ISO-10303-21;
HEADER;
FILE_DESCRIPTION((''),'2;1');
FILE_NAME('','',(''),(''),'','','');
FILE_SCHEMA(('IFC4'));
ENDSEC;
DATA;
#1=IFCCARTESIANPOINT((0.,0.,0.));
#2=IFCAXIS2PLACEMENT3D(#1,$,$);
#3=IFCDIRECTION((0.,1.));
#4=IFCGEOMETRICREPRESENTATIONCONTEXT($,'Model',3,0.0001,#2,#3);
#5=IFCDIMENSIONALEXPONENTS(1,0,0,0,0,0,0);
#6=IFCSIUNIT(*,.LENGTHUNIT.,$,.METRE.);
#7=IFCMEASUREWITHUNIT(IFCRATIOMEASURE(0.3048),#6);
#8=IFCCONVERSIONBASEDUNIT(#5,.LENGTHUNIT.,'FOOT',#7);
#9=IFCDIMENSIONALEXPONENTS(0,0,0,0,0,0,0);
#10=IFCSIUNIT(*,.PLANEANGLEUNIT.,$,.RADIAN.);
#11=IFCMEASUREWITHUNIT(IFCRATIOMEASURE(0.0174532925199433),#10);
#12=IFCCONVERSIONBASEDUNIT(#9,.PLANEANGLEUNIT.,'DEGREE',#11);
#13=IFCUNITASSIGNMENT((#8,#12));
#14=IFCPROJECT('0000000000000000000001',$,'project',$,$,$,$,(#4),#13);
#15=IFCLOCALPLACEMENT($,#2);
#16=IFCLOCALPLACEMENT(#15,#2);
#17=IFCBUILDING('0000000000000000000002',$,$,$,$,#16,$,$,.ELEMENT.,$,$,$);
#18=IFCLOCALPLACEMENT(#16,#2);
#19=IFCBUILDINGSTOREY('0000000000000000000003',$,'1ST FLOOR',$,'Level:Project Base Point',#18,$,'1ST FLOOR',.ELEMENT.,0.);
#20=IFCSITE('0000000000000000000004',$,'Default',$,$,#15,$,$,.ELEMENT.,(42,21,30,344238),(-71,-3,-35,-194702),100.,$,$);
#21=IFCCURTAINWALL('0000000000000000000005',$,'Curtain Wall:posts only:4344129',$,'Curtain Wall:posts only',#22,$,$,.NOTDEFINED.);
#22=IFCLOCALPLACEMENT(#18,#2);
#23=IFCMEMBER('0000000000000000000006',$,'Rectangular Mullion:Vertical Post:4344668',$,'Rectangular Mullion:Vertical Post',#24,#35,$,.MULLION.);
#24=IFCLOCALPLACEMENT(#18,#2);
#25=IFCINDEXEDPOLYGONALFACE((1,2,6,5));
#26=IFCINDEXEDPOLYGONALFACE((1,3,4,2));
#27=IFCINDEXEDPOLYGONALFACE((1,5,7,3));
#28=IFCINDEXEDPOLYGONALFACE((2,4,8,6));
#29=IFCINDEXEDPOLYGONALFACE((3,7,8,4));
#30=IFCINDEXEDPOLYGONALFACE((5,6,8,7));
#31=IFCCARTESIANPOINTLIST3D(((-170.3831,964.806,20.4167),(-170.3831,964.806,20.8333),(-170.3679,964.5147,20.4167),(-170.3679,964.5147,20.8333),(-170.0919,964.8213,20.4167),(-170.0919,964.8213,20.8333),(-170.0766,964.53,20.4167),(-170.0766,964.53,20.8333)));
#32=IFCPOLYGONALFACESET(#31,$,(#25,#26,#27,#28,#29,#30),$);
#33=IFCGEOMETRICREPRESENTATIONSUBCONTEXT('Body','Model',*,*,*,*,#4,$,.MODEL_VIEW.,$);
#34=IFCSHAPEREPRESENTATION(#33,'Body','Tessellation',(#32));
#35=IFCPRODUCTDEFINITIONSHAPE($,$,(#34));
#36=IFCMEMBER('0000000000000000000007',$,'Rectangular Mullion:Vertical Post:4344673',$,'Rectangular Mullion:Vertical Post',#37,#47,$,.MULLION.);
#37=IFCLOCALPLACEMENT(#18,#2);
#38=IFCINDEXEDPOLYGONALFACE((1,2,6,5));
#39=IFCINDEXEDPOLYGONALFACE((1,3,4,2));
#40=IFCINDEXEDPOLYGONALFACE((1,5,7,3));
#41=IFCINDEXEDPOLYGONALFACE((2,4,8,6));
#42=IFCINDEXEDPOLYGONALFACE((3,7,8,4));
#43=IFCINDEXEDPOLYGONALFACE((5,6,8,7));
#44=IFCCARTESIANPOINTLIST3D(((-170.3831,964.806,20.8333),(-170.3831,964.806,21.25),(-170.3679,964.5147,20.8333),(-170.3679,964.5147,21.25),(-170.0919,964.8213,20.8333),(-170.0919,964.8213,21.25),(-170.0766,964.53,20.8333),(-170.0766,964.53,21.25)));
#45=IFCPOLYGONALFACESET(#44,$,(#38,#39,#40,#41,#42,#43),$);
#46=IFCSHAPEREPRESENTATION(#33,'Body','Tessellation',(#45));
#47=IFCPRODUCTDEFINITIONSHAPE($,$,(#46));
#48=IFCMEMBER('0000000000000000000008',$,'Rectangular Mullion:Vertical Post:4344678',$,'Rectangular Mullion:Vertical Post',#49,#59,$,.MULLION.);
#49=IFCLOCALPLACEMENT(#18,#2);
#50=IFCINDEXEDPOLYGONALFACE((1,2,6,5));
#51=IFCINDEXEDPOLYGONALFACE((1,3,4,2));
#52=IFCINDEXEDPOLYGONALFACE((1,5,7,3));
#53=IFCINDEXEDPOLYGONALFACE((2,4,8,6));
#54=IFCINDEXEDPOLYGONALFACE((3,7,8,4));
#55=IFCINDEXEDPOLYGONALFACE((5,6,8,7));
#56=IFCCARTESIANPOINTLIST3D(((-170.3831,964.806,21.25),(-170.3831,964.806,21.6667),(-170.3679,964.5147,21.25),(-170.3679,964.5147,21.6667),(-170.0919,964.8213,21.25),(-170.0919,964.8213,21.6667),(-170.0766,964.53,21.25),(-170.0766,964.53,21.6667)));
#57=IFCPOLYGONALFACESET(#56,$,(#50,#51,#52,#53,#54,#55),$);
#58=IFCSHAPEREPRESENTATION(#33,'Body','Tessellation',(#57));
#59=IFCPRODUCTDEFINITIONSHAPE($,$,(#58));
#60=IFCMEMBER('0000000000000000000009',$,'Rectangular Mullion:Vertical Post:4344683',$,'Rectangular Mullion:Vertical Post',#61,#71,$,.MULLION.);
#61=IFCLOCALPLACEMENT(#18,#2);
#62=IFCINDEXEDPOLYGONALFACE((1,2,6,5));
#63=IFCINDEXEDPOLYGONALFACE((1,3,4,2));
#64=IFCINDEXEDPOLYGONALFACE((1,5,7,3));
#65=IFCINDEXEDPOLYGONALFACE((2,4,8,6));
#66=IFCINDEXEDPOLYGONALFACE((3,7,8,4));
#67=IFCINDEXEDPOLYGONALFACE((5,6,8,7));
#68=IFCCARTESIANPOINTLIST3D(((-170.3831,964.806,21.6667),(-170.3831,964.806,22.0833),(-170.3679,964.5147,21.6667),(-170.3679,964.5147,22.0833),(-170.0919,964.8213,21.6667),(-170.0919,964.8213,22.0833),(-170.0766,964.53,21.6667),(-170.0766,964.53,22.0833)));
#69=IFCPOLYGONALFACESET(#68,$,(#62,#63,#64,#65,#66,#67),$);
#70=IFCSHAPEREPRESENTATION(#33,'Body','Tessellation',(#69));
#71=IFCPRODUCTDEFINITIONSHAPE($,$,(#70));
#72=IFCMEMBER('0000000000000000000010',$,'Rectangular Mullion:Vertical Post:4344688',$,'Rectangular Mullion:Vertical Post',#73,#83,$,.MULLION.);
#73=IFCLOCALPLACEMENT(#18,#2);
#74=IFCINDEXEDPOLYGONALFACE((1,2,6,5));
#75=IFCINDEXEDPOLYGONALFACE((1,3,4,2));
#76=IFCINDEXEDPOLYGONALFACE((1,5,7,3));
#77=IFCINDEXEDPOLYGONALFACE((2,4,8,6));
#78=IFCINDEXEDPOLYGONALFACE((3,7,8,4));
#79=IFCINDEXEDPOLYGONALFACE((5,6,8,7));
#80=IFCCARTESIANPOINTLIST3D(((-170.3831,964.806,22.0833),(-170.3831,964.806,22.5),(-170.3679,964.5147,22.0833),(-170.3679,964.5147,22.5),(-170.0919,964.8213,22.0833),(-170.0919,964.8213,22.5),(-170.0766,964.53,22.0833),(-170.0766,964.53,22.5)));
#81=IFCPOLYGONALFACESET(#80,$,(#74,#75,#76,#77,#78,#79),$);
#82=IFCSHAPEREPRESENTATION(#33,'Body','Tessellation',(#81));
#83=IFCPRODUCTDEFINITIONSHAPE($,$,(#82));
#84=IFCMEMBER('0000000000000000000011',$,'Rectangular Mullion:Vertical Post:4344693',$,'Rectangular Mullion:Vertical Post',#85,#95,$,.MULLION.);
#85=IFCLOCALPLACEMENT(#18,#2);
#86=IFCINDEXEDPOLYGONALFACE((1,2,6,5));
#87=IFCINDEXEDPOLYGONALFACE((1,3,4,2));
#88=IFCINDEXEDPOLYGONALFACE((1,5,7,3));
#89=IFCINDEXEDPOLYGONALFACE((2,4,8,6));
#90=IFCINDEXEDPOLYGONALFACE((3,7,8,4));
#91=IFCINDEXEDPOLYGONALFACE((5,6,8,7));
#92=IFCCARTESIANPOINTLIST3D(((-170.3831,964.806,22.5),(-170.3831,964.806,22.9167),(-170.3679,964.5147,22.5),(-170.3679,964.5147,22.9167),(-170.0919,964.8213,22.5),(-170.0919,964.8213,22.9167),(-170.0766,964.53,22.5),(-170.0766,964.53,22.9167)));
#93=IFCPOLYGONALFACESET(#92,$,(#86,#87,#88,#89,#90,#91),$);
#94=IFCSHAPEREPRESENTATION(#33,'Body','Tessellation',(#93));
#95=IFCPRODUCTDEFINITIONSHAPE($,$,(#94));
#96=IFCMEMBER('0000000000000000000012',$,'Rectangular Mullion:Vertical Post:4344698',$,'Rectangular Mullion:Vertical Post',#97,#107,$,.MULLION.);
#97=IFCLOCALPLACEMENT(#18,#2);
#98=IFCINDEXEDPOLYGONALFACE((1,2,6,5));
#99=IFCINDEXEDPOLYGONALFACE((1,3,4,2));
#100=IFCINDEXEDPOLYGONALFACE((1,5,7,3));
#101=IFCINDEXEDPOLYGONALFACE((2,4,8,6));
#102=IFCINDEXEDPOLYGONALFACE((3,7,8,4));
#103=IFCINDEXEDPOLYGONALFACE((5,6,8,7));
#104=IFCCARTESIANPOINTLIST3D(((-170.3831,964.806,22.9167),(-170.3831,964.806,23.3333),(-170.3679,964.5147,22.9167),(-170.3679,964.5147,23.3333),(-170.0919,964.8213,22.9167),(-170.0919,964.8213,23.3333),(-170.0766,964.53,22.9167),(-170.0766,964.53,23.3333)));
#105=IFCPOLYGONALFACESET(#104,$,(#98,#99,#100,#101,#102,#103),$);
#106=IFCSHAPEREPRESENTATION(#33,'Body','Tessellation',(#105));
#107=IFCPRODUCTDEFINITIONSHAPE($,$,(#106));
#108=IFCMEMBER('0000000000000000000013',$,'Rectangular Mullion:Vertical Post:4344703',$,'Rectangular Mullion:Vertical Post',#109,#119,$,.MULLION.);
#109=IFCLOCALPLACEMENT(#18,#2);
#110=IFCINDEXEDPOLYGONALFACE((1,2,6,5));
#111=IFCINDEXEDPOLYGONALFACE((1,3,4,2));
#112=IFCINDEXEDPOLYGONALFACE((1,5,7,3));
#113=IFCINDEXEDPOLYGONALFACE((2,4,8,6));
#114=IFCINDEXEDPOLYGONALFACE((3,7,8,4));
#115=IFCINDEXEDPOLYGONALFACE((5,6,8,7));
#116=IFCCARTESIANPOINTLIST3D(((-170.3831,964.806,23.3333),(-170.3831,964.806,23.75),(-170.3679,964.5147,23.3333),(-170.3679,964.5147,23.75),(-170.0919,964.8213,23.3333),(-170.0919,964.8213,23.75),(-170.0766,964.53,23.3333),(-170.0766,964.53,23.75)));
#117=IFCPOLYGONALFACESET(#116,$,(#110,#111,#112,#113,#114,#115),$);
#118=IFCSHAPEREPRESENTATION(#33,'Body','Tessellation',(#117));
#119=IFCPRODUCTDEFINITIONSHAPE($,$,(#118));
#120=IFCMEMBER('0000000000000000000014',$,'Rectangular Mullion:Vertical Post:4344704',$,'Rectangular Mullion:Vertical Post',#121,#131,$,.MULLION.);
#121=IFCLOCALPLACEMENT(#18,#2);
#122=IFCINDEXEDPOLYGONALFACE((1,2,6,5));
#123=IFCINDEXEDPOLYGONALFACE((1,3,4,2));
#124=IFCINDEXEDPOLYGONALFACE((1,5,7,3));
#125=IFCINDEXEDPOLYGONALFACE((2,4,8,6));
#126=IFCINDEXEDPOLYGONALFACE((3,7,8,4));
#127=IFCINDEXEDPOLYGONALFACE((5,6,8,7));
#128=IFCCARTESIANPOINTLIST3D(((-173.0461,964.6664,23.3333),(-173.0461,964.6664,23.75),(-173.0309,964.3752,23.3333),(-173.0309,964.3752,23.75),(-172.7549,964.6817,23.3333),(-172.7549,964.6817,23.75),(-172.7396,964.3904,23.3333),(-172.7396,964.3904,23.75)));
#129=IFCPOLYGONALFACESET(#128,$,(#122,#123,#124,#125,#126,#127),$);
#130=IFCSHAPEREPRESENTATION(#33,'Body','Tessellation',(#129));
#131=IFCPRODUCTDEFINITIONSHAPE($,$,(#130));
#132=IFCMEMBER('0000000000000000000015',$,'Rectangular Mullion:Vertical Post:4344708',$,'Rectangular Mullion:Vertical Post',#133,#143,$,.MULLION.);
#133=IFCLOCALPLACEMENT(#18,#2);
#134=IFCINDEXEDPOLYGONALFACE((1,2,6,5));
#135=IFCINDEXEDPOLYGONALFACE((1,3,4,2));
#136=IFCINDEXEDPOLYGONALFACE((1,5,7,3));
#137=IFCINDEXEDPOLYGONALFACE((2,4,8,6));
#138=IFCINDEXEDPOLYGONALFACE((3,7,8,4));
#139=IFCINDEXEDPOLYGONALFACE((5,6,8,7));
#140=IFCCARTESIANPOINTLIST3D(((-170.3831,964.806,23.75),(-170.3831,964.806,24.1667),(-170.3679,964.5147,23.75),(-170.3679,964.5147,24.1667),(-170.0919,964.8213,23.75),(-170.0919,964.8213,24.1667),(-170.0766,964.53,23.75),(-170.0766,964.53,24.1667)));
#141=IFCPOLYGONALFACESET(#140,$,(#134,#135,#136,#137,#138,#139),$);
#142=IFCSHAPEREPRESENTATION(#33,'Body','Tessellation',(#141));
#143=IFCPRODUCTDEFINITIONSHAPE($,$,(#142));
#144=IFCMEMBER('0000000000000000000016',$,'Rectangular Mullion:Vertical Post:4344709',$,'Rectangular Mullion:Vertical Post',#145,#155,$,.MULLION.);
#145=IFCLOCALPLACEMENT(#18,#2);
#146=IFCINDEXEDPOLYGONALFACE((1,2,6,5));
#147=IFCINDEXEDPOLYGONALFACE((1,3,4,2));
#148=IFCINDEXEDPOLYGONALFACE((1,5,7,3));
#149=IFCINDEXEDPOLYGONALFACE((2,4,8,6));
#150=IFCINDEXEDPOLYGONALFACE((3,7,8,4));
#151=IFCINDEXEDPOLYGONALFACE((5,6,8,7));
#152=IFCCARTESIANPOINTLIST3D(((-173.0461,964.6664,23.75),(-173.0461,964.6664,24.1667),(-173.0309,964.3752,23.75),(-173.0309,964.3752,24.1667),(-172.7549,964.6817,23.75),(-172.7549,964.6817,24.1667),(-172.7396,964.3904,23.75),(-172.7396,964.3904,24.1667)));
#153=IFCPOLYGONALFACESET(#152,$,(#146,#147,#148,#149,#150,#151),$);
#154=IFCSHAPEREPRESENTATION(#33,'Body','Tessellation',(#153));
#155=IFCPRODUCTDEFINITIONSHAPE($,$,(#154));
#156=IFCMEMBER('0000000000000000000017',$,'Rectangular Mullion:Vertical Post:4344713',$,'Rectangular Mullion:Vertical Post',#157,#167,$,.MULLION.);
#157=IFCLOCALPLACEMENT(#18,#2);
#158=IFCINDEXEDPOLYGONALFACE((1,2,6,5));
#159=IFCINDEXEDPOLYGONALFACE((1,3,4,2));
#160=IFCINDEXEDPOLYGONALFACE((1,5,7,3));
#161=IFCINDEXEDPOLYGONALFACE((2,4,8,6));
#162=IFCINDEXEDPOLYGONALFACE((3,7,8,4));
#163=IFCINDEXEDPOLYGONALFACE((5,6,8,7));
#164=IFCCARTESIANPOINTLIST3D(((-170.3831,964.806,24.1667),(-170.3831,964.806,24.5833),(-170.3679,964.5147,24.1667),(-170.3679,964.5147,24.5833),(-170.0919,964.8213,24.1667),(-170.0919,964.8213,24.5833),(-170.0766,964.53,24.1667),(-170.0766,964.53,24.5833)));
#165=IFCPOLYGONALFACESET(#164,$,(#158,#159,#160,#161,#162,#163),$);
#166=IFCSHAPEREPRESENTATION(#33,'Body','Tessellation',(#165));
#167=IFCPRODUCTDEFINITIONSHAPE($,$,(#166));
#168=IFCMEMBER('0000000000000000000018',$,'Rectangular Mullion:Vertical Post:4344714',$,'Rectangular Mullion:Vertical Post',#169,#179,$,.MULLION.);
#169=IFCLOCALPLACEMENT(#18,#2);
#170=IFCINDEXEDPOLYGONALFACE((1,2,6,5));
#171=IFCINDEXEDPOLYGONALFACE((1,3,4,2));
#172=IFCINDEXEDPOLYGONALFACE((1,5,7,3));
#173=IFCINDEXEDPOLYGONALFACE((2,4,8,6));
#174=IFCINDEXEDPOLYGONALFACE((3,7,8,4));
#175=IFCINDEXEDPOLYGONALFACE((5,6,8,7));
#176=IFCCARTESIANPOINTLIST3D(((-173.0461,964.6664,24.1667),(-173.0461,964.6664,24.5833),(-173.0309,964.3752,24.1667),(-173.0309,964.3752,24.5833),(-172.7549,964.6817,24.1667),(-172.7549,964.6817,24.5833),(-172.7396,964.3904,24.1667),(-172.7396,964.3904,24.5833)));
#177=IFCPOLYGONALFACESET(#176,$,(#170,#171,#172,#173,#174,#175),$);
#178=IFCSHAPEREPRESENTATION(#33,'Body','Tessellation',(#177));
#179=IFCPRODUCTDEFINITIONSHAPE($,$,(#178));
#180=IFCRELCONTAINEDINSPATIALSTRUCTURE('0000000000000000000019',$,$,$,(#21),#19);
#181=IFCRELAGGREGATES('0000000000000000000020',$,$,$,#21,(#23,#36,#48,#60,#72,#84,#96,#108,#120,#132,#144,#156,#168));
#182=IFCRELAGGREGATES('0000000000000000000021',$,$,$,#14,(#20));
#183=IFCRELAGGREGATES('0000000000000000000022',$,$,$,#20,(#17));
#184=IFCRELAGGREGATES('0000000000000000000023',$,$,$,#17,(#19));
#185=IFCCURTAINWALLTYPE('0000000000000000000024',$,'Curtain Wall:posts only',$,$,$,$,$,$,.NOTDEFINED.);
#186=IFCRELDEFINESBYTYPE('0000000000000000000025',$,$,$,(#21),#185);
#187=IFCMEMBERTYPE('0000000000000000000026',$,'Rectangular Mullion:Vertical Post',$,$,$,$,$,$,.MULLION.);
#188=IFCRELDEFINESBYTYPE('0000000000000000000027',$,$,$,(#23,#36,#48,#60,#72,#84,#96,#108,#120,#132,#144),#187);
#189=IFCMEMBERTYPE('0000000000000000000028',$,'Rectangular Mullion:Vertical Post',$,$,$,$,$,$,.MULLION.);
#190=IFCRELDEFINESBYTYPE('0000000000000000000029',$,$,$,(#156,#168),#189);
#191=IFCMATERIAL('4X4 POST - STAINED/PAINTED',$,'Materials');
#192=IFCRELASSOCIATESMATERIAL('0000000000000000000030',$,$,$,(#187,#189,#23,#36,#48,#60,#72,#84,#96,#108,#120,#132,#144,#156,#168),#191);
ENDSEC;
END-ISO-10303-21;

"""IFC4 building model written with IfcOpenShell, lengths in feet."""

from ifc_helpers import new_model, entity, si_unit, converted_unit, direction, frame, origin, origin_2d_with_axis, place, context, subcontext, project, spatial, rectangle, extrude, source, transform, mapped, material, material_profile, profile_set, profile_usage, type_object, type_shapes, element, aggregate, save


model = new_model("IFC4")

# Units and contexts
model_context = context("Model", 3, precision=0.0001, world=origin(), true_north=direction((0.0, 1.0)))
body_context = subcontext(model_context, "Body", "Model", "MODEL_VIEW")
ifc_project = project(units=[converted_unit("LENGTHUNIT", "FOOT", entity("IfcRatioMeasure", 0.3048), si_unit("LENGTHUNIT", "METRE"), dimensions=[1, 0, 0, 0, 0, 0, 0]), converted_unit("PLANEANGLEUNIT", "DEGREE", entity("IfcRatioMeasure", 0.0174532925199433), si_unit("PLANEANGLEUNIT", "RADIAN"), dimensions=[0, 0, 0, 0, 0, 0, 0])], contexts=[model_context])

# Site, building, storey
site_placement = place(None, origin())
site = spatial("IfcSite", under=ifc_project, at=site_placement, Name="Default", CompositionType="ELEMENT", RefLatitude=(42, 21, 30, 344238), RefLongitude=(-71, -3, -35, -194702), RefElevation=100.0)
building_placement = place(site_placement, origin())
building = spatial("IfcBuilding", under=site, at=building_placement, CompositionType="ELEMENT")
storey_placement = place(building_placement, origin())
storey = spatial("IfcBuildingStorey", under=building, at=storey_placement, Name="1ST FLOOR", ObjectType="Level:Project Base Point", LongName="1ST FLOOR", CompositionType="ELEMENT", Elevation=0.0)

# Curtain wall, members
curtain_wall_type_1 = type_object("IfcCurtainWallType", Name="Curtain Wall:posts only", PredefinedType="NOTDEFINED")
curtain_wall_1_placement = place(storey_placement, origin())
curtain_wall_1 = element("IfcCurtainWall", 1, at=curtain_wall_1_placement, inside=storey, type_object=curtain_wall_type_1, Name="Curtain Wall:posts only:4344129", ObjectType="Curtain Wall:posts only", PredefinedType="NOTDEFINED")
ifc_material_1 = material(Name="4X4 POST - STAINED/PAINTED", Category="Materials")
ifc_material_profile_1 = material_profile(ifc_material_1, rectangle(XDim=0.2917, YDim=0.2917, at=origin_2d_with_axis()), Name="Vertical Post")
ifc_profile_set_1 = profile_set([ifc_material_profile_1], Name="Vertical Post")
ifc_profile_usage_1 = profile_usage(ifc_profile_set_1)
member_type_1 = type_object("IfcMemberType", Name="Rectangular Mullion:Vertical Post", PredefinedType="MULLION", material=ifc_profile_set_1)
shared_shape_1 = source(origin(), body_context, "Body", "SweptSolid", [
    extrude(rectangle(XDim=0.2917, YDim=0.2917, at=origin_2d_with_axis()), frame((0.0, -0.2083, -0.4167), z_axis=(0.0, 0.0, 1.0), x_axis=(0.0, -1.0, 0.0)), (0.0, 0.0, 1.0), 0.4167),
])
type_shapes(member_type_1, [shared_shape_1])
member_1_placement = place(storey_placement, frame((-170.2408, 964.8761, 20.4167), z_axis=(0.0, 0.0, -1.0), x_axis=(-0.99863, -0.052336, 0.0)))
member_1 = element("IfcMember", 2, at=member_1_placement, type_object=member_type_1, material=ifc_profile_usage_1, Name="Rectangular Mullion:Vertical Post:4344668", ObjectType="Rectangular Mullion:Vertical Post", PredefinedType="MULLION", context=body_context, shape_type="MappedRepresentation", body=[
    mapped(shared_shape_1, transform((0.0, 0.0, 0.0), scale=1.0)),
])
ifc_profile_usage_2 = profile_usage(ifc_profile_set_1)
member_2_placement = place(storey_placement, frame((-170.2408, 964.8761, 20.8333), z_axis=(0.0, 0.0, -1.0), x_axis=(-0.99863, -0.052336, 0.0)))
member_2 = element("IfcMember", 3, at=member_2_placement, type_object=member_type_1, material=ifc_profile_usage_2, Name="Rectangular Mullion:Vertical Post:4344673", ObjectType="Rectangular Mullion:Vertical Post", PredefinedType="MULLION", context=body_context, shape_type="MappedRepresentation", body=[
    mapped(shared_shape_1, transform((0.0, 0.0, 0.0), scale=1.0)),
])
ifc_profile_usage_3 = profile_usage(ifc_profile_set_1)
member_3_placement = place(storey_placement, frame((-170.2408, 964.8761, 21.25), z_axis=(0.0, 0.0, -1.0), x_axis=(-0.99863, -0.052336, 0.0)))
member_3 = element("IfcMember", 4, at=member_3_placement, type_object=member_type_1, material=ifc_profile_usage_3, Name="Rectangular Mullion:Vertical Post:4344678", ObjectType="Rectangular Mullion:Vertical Post", PredefinedType="MULLION", context=body_context, shape_type="MappedRepresentation", body=[
    mapped(shared_shape_1, transform((0.0, 0.0, 0.0), scale=1.0)),
])
ifc_profile_usage_4 = profile_usage(ifc_profile_set_1)
member_4_placement = place(storey_placement, frame((-170.2408, 964.8761, 21.6667), z_axis=(0.0, 0.0, -1.0), x_axis=(-0.99863, -0.052336, 0.0)))
member_4 = element("IfcMember", 5, at=member_4_placement, type_object=member_type_1, material=ifc_profile_usage_4, Name="Rectangular Mullion:Vertical Post:4344683", ObjectType="Rectangular Mullion:Vertical Post", PredefinedType="MULLION", context=body_context, shape_type="MappedRepresentation", body=[
    mapped(shared_shape_1, transform((0.0, 0.0, 0.0), scale=1.0)),
])
ifc_profile_usage_5 = profile_usage(ifc_profile_set_1)
member_5_placement = place(storey_placement, frame((-170.2408, 964.8761, 22.0833), z_axis=(0.0, 0.0, -1.0), x_axis=(-0.99863, -0.052336, 0.0)))
member_5 = element("IfcMember", 6, at=member_5_placement, type_object=member_type_1, material=ifc_profile_usage_5, Name="Rectangular Mullion:Vertical Post:4344688", ObjectType="Rectangular Mullion:Vertical Post", PredefinedType="MULLION", context=body_context, shape_type="MappedRepresentation", body=[
    mapped(shared_shape_1, transform((0.0, 0.0, 0.0), scale=1.0)),
])
ifc_profile_usage_6 = profile_usage(ifc_profile_set_1)
member_6_placement = place(storey_placement, frame((-170.2408, 964.8761, 22.5), z_axis=(0.0, 0.0, -1.0), x_axis=(-0.99863, -0.052336, 0.0)))
member_6 = element("IfcMember", 7, at=member_6_placement, type_object=member_type_1, material=ifc_profile_usage_6, Name="Rectangular Mullion:Vertical Post:4344693", ObjectType="Rectangular Mullion:Vertical Post", PredefinedType="MULLION", context=body_context, shape_type="MappedRepresentation", body=[
    mapped(shared_shape_1, transform((0.0, 0.0, 0.0), scale=1.0)),
])
ifc_profile_usage_7 = profile_usage(ifc_profile_set_1)
member_7_placement = place(storey_placement, frame((-170.2408, 964.8761, 22.9167), z_axis=(0.0, 0.0, -1.0), x_axis=(-0.99863, -0.052336, 0.0)))
member_7 = element("IfcMember", 8, at=member_7_placement, type_object=member_type_1, material=ifc_profile_usage_7, Name="Rectangular Mullion:Vertical Post:4344698", ObjectType="Rectangular Mullion:Vertical Post", PredefinedType="MULLION", context=body_context, shape_type="MappedRepresentation", body=[
    mapped(shared_shape_1, transform((0.0, 0.0, 0.0), scale=1.0)),
])
ifc_profile_usage_8 = profile_usage(ifc_profile_set_1)
member_8_placement = place(storey_placement, frame((-170.2408, 964.8761, 23.3333), z_axis=(0.0, 0.0, -1.0), x_axis=(-0.99863, -0.052336, 0.0)))
member_8 = element("IfcMember", 9, at=member_8_placement, type_object=member_type_1, material=ifc_profile_usage_8, Name="Rectangular Mullion:Vertical Post:4344703", ObjectType="Rectangular Mullion:Vertical Post", PredefinedType="MULLION", context=body_context, shape_type="MappedRepresentation", body=[
    mapped(shared_shape_1, transform((0.0, 0.0, 0.0), scale=1.0)),
])
ifc_profile_usage_9 = profile_usage(ifc_profile_set_1)
member_9_placement = place(storey_placement, frame((-172.9038, 964.7365, 23.3333), z_axis=(0.0, 0.0, -1.0), x_axis=(-0.99863, -0.052336, 0.0)))
member_9 = element("IfcMember", 10, at=member_9_placement, type_object=member_type_1, material=ifc_profile_usage_9, Name="Rectangular Mullion:Vertical Post:4344704", ObjectType="Rectangular Mullion:Vertical Post", PredefinedType="MULLION", context=body_context, shape_type="MappedRepresentation", body=[
    mapped(shared_shape_1, transform((0.0, 0.0, 0.0), scale=1.0)),
])
ifc_profile_usage_10 = profile_usage(ifc_profile_set_1)
member_10_placement = place(storey_placement, frame((-170.2408, 964.8761, 23.75), z_axis=(0.0, 0.0, -1.0), x_axis=(-0.99863, -0.052336, 0.0)))
member_10 = element("IfcMember", 11, at=member_10_placement, type_object=member_type_1, material=ifc_profile_usage_10, Name="Rectangular Mullion:Vertical Post:4344708", ObjectType="Rectangular Mullion:Vertical Post", PredefinedType="MULLION", context=body_context, shape_type="MappedRepresentation", body=[
    mapped(shared_shape_1, transform((0.0, 0.0, 0.0), scale=1.0)),
])
ifc_profile_usage_11 = profile_usage(ifc_profile_set_1)
member_11_placement = place(storey_placement, frame((-172.9038, 964.7365, 23.75), z_axis=(0.0, 0.0, -1.0), x_axis=(-0.99863, -0.052336, 0.0)))
member_11 = element("IfcMember", 12, at=member_11_placement, type_object=member_type_1, material=ifc_profile_usage_11, Name="Rectangular Mullion:Vertical Post:4344709", ObjectType="Rectangular Mullion:Vertical Post", PredefinedType="MULLION", context=body_context, shape_type="MappedRepresentation", body=[
    mapped(shared_shape_1, transform((0.0, 0.0, 0.0), scale=1.0)),
])
ifc_profile_usage_12 = profile_usage(ifc_profile_set_1)
member_type_2 = type_object("IfcMemberType", Name="Rectangular Mullion:Vertical Post", PredefinedType="MULLION", material=ifc_profile_set_1)
shared_shape_2 = source(origin(), body_context, "Body", "SweptSolid", [
    extrude(rectangle(XDim=0.2917, YDim=0.2917, at=origin_2d_with_axis()), frame((0.0, -0.2083, -0.4167), z_axis=(0.0, 0.0, 1.0), x_axis=(0.0, -1.0, 0.0)), (0.0, 0.0, 1.0), 0.4167),
])
type_shapes(member_type_2, [shared_shape_2])
member_12_placement = place(storey_placement, frame((-170.2408, 964.8761, 24.1667), z_axis=(0.0, 0.0, -1.0), x_axis=(-0.99863, -0.052336, 0.0)))
member_12 = element("IfcMember", 13, at=member_12_placement, type_object=member_type_2, material=ifc_profile_usage_12, Name="Rectangular Mullion:Vertical Post:4344713", ObjectType="Rectangular Mullion:Vertical Post", PredefinedType="MULLION", context=body_context, shape_type="MappedRepresentation", body=[
    mapped(shared_shape_2, transform((0.0, 0.0, 0.0), scale=1.0)),
])
ifc_profile_usage_13 = profile_usage(ifc_profile_set_1)
member_13_placement = place(storey_placement, frame((-172.9038, 964.7365, 24.1667), z_axis=(0.0, 0.0, -1.0), x_axis=(-0.99863, -0.052336, 0.0)))
member_13 = element("IfcMember", 14, at=member_13_placement, type_object=member_type_2, material=ifc_profile_usage_13, Name="Rectangular Mullion:Vertical Post:4344714", ObjectType="Rectangular Mullion:Vertical Post", PredefinedType="MULLION", context=body_context, shape_type="MappedRepresentation", body=[
    mapped(shared_shape_2, transform((0.0, 0.0, 0.0), scale=1.0)),
])
aggregate(curtain_wall_1, [member_1, member_2, member_3, member_4, member_5, member_6, member_7, member_8, member_9, member_10, member_11, member_12, member_13])

save(model, "model.ifc")
